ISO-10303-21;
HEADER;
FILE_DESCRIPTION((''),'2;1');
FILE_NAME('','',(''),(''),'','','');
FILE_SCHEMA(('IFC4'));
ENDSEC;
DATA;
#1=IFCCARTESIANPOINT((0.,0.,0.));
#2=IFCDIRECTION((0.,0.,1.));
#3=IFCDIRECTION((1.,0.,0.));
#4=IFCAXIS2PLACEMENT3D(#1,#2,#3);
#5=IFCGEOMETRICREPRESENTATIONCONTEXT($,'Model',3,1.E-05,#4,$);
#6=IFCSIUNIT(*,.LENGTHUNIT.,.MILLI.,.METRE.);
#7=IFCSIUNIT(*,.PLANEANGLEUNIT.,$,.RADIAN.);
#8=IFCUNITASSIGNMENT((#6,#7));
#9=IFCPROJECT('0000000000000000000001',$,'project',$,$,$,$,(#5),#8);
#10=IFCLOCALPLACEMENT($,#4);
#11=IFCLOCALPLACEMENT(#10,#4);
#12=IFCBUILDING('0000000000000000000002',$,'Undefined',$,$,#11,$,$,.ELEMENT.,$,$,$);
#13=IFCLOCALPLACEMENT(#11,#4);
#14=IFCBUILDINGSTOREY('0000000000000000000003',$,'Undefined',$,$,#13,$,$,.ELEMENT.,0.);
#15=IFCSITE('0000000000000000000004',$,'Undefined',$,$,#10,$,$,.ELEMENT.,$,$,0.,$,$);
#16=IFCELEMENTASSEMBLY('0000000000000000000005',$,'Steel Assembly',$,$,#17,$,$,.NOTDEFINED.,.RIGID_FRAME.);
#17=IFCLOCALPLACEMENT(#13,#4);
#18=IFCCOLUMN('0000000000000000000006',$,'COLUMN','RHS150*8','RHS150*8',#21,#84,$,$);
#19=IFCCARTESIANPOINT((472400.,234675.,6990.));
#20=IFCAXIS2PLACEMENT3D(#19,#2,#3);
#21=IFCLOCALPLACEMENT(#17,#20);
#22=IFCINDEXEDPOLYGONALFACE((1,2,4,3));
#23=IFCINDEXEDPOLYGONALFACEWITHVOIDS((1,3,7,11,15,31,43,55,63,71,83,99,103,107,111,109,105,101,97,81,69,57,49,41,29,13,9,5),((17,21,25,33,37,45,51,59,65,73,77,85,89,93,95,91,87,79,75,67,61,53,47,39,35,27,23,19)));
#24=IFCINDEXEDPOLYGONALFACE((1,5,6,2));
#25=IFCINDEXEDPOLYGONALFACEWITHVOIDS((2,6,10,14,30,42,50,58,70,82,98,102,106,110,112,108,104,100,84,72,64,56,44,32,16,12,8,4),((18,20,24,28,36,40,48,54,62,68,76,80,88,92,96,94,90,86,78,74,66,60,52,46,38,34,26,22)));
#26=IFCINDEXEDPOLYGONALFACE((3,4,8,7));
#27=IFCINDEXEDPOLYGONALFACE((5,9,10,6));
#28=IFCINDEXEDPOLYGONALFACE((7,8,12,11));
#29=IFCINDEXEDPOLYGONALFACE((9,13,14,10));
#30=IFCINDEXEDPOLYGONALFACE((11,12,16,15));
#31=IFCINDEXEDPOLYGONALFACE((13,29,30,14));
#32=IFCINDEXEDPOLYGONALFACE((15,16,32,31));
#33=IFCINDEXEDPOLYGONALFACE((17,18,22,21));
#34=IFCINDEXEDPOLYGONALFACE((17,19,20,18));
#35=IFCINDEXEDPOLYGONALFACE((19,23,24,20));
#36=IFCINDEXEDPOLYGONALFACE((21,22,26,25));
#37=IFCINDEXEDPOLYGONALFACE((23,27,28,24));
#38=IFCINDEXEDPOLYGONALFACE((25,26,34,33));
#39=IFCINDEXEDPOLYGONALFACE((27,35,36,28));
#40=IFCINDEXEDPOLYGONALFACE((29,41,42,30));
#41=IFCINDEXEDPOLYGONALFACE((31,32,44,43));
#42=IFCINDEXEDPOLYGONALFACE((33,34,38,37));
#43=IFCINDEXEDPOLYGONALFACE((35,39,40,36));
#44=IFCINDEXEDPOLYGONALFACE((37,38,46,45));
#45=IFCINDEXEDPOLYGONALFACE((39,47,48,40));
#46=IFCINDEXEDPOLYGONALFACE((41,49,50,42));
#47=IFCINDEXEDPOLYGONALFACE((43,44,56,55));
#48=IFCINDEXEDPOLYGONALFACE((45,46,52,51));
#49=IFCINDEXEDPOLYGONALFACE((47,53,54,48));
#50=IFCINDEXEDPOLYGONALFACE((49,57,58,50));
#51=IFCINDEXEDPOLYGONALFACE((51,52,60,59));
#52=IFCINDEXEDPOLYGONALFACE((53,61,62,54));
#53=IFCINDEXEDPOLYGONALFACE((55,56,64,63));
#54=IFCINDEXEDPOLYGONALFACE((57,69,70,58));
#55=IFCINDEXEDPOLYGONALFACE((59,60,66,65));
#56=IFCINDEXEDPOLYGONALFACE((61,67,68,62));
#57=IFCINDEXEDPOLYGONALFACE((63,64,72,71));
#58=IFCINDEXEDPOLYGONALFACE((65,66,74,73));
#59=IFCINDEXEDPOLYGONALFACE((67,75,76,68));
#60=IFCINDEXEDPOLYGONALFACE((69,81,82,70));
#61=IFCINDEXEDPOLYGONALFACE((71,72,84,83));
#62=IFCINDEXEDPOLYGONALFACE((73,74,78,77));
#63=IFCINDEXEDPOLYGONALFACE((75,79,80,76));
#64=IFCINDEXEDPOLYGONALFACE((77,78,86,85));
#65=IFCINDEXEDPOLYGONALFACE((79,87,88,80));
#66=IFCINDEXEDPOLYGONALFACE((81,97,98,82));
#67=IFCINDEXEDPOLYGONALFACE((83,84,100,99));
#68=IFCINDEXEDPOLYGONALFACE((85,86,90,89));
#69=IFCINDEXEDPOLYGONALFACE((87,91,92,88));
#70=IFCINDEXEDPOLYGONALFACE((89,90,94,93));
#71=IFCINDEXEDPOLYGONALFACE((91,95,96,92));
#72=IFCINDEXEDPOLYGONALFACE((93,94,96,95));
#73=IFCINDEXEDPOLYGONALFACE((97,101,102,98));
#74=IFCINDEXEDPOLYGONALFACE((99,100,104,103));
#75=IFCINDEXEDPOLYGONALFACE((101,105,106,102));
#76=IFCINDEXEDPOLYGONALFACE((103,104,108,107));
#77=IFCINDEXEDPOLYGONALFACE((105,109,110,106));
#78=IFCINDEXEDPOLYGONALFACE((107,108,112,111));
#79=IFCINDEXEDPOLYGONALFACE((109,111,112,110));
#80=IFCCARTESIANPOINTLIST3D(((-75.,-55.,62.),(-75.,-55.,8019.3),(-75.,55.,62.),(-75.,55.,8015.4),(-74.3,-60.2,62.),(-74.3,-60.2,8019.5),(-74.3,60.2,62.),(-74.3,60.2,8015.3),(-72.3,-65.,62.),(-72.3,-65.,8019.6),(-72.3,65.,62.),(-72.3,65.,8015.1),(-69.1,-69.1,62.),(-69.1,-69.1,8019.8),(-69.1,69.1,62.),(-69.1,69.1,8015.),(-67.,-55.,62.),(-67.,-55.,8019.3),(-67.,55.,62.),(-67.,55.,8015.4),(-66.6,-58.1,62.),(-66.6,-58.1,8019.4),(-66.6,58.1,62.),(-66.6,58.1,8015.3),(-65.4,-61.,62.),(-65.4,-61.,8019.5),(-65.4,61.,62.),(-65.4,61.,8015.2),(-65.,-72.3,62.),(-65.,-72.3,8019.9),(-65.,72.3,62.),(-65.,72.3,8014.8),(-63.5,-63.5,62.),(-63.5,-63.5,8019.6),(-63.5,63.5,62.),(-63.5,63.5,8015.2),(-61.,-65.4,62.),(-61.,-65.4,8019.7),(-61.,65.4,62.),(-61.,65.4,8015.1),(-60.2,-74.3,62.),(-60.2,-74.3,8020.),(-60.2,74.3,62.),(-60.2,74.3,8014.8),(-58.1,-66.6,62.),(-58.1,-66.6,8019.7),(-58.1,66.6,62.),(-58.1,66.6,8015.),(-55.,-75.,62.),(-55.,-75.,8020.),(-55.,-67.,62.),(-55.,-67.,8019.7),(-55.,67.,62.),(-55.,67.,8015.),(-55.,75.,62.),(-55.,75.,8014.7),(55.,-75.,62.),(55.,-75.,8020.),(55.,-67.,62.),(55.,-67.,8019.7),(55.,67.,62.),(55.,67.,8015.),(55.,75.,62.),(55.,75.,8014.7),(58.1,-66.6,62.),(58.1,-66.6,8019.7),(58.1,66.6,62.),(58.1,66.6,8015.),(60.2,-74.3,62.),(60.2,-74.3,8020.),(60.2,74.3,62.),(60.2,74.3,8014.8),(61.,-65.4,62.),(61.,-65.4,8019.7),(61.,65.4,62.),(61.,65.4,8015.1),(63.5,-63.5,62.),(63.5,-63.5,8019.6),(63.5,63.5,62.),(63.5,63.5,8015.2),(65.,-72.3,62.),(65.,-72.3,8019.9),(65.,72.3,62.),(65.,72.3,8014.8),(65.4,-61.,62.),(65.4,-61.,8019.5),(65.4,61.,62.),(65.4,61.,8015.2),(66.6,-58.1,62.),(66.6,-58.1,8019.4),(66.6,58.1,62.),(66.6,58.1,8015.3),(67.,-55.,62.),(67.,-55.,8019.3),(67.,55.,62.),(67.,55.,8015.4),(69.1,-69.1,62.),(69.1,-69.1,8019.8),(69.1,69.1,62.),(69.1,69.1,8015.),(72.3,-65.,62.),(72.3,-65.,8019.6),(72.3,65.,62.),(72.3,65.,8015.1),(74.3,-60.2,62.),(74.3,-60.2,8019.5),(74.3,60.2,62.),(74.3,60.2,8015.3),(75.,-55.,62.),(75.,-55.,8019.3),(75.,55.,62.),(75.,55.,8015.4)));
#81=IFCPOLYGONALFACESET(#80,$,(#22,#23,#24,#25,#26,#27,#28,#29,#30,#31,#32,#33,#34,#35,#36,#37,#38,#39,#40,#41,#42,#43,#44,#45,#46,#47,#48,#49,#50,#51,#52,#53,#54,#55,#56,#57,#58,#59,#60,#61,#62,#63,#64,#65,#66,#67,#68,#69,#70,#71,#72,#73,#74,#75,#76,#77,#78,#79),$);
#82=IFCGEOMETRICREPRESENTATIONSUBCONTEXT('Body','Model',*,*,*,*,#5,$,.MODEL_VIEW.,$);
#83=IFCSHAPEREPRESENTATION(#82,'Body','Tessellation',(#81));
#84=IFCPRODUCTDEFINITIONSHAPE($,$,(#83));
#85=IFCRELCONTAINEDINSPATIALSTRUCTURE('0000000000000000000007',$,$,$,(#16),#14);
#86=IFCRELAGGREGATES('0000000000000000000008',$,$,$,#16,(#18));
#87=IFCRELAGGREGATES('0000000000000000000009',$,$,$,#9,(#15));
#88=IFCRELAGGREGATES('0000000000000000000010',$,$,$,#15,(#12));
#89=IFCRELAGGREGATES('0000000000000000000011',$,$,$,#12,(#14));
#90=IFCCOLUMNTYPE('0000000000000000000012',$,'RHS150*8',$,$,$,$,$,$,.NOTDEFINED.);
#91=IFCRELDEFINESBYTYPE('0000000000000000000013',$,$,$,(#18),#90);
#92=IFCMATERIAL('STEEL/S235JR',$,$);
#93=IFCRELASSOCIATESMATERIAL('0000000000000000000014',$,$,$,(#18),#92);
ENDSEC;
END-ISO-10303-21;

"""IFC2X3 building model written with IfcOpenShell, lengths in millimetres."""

from ifc_helpers import new_model, si_unit, frame, origin_with_axes, origin_2d_with_axis, place, context, subcontext, project, spatial, hollow_rectangle, extrude, clip, halfspace, material, type_object, element, aggregate, save


model = new_model("IFC2X3")

# Units and contexts
model_context = context("Model", 3, precision=1e-05, world=origin_with_axes())
body_context = subcontext(model_context, "Body", "Model", "MODEL_VIEW")
ifc_project = project(units=[si_unit("LENGTHUNIT", "METRE", prefix="MILLI"), si_unit("PLANEANGLEUNIT", "RADIAN")], contexts=[model_context])

# Site, building, storey
site_placement = place(None, origin_with_axes())
site = spatial("IfcSite", under=ifc_project, at=site_placement, Name="Undefined", CompositionType="ELEMENT", RefElevation=0.0)
building_placement = place(site_placement, origin_with_axes())
building = spatial("IfcBuilding", under=site, at=building_placement, Name="Undefined", CompositionType="ELEMENT")
storey_placement = place(building_placement, origin_with_axes())
storey = spatial("IfcBuildingStorey", under=building, at=storey_placement, Name="Undefined", CompositionType="ELEMENT", Elevation=0.0)

# Element assembly, column
assembly_1_placement = place(storey_placement, origin_with_axes())
assembly_1 = element("IfcElementAssembly", 1, at=assembly_1_placement, inside=storey, Name="Steel Assembly", AssemblyPlace="NOTDEFINED", PredefinedType="RIGID_FRAME")
ifc_material_1 = material(Name="STEEL/S235JR")
column_type = type_object("IfcColumnType", Name="RHS150*8", PredefinedType="NOTDEFINED")
column_placement = place(assembly_1_placement, frame((472400.0, 234675.0, 6990.0), z_axis=(0.0, 0.0, 1.0), x_axis=(1.0, 0.0, 0.0)))
column = element("IfcColumn", 2, at=column_placement, type_object=column_type, material=ifc_material_1, Name="COLUMN", Description="RHS150*8", ObjectType="RHS150*8", context=body_context, shape_type="Clipping", body=[
    clip(extrude(hollow_rectangle(XDim=150.0, YDim=150.0, WallThickness=8.0, InnerFilletRadius=12.0, OuterFilletRadius=20.0, at=origin_2d_with_axis()), frame((0.0, 0.0, 8020.0), z_axis=(0.0, 0.0, -1.0), x_axis=(-1.0, 0.0, 0.0)), (0.0, 0.0, 1.0), 7958.0), halfspace(frame((0.0, -90.6, 8020.5), z_axis=(0.0, -0.034899, -0.999391), x_axis=(1.0, 0.0, 0.0)), True)),
])

aggregate(assembly_1, [column])

save(model, "model.ifc")
